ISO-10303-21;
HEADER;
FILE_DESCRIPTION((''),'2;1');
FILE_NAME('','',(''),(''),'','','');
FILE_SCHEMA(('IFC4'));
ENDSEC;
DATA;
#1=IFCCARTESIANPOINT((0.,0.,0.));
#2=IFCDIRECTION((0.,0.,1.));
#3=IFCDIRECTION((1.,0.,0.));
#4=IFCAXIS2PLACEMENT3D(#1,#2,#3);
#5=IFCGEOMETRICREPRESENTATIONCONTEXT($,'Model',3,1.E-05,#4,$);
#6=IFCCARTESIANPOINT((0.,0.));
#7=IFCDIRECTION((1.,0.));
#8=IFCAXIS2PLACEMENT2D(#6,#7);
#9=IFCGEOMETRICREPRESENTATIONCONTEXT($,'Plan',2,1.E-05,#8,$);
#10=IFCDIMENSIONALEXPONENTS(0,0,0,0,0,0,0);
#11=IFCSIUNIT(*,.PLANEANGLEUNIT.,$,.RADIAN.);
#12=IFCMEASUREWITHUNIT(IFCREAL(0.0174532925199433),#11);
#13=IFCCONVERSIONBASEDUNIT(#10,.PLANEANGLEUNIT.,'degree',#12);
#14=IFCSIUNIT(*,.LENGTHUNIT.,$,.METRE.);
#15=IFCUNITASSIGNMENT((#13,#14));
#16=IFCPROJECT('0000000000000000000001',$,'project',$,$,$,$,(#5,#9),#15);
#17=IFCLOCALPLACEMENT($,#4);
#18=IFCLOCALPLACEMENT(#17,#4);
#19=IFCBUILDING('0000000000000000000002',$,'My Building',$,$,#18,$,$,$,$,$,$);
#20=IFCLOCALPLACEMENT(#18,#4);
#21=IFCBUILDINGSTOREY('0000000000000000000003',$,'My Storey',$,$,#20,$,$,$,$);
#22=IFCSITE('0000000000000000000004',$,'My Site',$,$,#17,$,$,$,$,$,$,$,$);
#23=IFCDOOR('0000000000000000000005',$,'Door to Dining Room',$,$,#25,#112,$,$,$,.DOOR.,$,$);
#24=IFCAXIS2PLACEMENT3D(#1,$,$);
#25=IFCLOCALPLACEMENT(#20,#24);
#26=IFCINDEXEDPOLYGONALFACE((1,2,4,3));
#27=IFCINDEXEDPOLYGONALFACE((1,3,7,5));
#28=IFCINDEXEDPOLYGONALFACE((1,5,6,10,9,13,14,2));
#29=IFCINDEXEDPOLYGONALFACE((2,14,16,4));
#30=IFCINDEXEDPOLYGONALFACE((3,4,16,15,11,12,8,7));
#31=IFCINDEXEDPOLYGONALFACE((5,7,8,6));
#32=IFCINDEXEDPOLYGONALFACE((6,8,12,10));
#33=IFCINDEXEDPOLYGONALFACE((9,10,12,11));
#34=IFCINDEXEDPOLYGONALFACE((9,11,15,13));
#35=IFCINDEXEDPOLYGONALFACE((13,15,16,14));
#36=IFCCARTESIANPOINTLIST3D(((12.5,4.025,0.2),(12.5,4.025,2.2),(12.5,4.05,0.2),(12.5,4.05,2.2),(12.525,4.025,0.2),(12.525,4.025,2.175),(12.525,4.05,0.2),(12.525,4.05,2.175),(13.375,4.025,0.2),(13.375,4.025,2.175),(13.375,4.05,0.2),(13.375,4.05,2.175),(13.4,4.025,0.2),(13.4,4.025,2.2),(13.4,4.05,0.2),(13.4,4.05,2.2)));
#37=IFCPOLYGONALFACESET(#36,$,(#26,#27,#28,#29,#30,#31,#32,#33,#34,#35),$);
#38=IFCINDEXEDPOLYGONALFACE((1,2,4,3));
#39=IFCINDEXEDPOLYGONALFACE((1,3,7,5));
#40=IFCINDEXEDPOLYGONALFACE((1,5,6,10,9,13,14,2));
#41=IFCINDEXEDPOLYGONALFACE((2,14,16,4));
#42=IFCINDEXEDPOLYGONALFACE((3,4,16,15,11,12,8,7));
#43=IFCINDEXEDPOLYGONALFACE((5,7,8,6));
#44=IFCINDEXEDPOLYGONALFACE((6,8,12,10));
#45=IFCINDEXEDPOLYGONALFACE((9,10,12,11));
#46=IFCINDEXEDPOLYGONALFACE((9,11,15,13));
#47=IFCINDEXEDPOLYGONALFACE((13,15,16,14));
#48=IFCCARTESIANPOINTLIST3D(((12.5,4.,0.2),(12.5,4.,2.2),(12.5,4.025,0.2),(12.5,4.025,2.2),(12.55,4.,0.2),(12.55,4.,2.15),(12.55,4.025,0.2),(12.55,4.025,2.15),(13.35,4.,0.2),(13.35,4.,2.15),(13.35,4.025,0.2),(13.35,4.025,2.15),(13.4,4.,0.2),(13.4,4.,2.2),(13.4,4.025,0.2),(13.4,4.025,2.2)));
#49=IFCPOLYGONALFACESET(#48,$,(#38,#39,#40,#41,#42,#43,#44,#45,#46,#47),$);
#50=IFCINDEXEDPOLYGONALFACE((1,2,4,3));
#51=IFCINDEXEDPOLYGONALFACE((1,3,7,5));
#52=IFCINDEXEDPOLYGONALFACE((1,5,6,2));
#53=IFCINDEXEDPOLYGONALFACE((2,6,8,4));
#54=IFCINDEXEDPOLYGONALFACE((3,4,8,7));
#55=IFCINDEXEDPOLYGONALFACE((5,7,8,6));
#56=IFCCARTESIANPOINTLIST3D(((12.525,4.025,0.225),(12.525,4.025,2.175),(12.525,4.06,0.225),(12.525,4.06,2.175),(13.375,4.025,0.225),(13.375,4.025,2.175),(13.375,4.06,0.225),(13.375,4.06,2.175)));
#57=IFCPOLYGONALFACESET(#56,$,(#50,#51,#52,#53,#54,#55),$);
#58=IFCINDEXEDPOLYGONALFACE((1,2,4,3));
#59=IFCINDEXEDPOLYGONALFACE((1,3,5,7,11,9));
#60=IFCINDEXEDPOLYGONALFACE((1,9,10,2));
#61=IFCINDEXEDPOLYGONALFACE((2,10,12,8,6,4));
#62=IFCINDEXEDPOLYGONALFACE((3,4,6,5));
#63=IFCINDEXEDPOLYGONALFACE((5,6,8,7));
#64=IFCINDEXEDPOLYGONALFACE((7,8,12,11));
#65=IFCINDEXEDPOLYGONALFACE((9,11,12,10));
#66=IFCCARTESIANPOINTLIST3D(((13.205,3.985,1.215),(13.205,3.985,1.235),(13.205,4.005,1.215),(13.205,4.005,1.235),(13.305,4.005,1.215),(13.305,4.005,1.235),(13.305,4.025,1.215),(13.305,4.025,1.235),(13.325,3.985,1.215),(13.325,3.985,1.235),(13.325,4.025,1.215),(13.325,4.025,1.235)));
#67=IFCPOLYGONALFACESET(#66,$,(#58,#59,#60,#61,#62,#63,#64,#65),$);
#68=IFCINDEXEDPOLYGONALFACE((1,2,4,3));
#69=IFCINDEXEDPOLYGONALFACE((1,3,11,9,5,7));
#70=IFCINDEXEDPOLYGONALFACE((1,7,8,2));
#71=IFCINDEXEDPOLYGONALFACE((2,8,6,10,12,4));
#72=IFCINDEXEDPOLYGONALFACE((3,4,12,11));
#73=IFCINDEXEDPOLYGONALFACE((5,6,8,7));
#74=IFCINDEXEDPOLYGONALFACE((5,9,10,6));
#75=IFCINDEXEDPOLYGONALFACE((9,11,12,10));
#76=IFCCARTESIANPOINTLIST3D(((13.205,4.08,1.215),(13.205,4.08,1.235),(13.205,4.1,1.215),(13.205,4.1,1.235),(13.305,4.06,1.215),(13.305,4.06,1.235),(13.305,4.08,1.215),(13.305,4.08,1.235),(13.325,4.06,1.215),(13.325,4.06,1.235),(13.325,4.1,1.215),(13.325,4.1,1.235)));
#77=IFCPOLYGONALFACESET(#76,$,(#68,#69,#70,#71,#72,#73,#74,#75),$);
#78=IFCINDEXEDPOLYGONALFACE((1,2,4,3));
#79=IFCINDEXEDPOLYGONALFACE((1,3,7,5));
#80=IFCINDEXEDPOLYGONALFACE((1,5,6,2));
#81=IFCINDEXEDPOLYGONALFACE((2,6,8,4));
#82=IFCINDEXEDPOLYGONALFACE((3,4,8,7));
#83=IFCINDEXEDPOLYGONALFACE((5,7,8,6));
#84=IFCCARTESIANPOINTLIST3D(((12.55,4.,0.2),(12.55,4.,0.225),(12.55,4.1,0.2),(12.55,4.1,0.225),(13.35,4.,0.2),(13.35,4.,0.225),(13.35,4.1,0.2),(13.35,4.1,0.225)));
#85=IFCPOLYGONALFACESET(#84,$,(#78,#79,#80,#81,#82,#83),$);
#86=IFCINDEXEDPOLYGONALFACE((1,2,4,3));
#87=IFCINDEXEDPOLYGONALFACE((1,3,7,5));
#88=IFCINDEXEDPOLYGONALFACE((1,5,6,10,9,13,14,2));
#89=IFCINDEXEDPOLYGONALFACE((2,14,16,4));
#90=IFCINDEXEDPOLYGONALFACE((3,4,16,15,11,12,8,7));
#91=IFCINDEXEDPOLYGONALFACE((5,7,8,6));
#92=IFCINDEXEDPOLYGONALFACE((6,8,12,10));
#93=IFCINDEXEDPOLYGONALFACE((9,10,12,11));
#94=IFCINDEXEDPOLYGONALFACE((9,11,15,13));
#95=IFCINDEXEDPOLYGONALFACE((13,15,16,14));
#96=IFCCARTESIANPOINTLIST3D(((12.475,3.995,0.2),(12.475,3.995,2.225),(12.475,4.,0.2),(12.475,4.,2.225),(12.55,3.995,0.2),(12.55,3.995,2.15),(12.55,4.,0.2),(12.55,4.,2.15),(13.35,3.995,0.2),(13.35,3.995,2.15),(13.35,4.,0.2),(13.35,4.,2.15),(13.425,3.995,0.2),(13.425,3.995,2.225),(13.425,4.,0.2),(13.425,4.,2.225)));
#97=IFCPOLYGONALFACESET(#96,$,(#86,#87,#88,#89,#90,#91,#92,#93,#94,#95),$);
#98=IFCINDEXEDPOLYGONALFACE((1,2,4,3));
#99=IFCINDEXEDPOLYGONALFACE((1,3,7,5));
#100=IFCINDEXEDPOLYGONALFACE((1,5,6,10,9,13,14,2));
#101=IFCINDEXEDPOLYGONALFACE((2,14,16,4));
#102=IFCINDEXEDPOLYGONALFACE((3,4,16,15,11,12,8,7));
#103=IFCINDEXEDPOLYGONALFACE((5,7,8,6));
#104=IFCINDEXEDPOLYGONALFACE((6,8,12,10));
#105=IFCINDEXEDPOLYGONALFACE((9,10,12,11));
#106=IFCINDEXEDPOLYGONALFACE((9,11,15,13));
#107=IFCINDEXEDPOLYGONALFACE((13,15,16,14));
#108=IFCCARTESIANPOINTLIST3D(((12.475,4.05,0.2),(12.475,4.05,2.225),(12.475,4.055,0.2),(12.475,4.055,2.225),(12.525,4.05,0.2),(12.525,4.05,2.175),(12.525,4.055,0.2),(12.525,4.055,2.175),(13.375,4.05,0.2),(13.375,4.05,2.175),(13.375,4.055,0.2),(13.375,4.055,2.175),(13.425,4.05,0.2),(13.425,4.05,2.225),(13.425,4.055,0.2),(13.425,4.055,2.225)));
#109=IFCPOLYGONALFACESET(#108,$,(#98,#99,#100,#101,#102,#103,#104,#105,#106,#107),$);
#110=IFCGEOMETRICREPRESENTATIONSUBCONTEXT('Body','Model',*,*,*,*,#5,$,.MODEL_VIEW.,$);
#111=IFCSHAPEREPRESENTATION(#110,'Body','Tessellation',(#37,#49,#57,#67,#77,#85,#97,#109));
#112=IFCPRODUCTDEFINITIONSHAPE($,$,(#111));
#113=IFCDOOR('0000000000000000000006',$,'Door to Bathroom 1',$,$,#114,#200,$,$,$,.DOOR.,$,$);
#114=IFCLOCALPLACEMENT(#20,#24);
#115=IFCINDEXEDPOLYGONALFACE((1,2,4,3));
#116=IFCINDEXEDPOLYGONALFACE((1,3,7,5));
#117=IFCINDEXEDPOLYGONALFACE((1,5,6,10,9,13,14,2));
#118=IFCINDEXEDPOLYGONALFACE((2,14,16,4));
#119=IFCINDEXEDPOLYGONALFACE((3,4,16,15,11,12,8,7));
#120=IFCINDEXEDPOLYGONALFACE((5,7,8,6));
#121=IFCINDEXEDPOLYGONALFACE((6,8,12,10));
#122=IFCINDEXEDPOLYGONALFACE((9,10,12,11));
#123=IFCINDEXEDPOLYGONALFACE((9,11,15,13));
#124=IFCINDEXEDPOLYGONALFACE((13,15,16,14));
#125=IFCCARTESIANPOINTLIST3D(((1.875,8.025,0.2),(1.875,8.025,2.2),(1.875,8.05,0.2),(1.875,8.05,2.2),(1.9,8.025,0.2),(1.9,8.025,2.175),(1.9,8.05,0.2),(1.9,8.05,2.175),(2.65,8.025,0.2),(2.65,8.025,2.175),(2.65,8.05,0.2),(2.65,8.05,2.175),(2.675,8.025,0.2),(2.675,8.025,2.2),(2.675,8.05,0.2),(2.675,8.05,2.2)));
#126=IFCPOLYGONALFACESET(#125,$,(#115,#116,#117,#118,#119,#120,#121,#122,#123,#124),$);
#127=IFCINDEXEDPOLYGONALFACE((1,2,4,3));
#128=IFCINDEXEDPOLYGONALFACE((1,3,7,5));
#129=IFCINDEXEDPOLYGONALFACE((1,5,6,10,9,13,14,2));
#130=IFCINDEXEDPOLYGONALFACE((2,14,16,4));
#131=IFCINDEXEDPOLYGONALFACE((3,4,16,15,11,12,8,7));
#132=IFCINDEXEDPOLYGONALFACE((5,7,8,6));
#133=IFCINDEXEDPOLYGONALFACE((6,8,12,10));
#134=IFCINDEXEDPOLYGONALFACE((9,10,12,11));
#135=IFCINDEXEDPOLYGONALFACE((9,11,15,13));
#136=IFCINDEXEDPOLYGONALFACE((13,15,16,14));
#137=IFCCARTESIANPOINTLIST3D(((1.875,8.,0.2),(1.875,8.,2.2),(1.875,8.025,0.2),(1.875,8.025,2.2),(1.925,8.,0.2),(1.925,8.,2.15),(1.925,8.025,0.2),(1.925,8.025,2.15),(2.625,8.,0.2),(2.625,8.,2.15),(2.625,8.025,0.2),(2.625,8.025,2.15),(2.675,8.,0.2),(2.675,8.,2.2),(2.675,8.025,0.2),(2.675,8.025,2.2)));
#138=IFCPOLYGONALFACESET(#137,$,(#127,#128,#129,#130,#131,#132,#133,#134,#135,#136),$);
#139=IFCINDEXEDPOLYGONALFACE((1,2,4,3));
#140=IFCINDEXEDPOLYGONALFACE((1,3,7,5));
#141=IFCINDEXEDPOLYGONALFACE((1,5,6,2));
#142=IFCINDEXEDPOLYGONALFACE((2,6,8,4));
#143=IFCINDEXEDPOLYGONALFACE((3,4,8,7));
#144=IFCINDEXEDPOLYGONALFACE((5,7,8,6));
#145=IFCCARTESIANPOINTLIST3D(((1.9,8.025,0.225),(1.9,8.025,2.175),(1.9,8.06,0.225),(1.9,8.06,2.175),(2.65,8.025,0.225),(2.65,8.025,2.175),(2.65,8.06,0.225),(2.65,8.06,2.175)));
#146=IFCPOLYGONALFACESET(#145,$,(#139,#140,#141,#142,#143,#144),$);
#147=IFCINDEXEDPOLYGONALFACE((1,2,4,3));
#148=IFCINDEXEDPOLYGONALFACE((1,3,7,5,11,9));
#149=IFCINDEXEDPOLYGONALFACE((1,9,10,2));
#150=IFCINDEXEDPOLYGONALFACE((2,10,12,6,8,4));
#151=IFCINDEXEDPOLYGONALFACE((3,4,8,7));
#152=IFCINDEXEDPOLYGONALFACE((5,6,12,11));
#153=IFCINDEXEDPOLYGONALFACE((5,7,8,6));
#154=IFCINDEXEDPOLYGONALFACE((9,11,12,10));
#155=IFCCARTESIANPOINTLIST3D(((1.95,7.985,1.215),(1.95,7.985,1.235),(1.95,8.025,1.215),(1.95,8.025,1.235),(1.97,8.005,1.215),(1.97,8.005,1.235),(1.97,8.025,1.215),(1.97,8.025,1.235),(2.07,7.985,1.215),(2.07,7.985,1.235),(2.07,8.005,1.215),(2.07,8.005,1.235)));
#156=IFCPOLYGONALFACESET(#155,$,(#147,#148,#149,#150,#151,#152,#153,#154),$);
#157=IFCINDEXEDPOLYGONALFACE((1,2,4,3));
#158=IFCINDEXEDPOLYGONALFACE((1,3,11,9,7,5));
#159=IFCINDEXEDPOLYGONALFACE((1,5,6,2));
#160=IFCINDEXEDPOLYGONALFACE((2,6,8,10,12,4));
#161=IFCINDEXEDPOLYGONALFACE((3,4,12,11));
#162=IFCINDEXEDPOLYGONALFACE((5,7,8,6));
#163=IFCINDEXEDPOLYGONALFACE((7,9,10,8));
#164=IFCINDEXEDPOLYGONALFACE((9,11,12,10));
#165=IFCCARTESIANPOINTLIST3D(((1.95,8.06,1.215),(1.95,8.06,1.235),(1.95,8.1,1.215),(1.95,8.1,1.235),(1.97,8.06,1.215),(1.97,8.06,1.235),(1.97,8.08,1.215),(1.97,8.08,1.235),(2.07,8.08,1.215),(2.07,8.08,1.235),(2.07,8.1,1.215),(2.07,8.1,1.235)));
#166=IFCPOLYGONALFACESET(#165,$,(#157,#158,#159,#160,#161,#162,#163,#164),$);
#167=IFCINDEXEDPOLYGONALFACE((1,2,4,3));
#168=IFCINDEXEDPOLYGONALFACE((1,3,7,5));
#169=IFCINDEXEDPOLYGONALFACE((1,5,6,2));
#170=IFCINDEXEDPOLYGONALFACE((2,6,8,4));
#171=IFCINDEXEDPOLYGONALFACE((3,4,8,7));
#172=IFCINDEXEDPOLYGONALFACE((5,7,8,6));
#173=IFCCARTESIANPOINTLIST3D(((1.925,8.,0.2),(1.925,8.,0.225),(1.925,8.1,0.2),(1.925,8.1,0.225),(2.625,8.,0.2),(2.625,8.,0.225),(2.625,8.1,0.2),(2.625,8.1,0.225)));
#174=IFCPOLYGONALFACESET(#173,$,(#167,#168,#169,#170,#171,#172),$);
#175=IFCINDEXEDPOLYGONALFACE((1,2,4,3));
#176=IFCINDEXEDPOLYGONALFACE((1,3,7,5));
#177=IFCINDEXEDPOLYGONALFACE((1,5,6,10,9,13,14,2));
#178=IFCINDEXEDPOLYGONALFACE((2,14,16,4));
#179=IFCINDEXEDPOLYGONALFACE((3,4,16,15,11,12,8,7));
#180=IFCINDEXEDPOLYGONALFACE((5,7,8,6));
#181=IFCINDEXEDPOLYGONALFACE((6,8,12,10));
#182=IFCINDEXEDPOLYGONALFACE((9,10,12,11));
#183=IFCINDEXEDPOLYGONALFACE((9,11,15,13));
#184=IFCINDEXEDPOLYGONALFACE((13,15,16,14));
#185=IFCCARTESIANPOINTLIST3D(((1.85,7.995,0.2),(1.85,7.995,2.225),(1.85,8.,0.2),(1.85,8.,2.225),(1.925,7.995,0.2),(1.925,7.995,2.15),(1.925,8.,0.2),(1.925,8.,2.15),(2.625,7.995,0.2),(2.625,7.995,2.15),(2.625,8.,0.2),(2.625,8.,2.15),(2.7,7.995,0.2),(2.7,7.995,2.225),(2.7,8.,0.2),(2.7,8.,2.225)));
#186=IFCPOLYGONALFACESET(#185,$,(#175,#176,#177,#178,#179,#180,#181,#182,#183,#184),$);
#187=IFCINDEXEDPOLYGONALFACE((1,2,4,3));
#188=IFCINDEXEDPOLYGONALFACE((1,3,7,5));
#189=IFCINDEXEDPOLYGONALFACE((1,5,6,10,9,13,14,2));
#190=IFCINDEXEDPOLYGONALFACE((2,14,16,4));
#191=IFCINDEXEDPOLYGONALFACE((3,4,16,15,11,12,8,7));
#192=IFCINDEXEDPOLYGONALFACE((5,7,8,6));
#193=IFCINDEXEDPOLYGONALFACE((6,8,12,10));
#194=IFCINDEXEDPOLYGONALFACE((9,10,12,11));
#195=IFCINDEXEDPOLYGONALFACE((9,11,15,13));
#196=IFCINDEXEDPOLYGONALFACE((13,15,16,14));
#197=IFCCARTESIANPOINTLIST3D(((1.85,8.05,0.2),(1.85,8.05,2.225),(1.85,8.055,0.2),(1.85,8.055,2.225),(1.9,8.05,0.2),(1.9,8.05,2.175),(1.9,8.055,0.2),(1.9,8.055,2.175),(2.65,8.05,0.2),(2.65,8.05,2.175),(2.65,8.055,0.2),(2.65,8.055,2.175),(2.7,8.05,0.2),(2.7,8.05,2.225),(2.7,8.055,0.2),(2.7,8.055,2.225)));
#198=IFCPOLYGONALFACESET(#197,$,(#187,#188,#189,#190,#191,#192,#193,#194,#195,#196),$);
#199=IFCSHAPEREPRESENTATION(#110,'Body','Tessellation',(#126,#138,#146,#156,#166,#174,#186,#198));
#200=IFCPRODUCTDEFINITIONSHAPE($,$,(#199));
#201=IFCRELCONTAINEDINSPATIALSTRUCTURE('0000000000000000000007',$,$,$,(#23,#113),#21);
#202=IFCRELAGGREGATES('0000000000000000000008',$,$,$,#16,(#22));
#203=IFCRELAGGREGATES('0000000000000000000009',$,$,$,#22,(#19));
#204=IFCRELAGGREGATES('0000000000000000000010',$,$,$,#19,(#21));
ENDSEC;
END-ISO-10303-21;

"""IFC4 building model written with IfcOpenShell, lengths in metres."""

from ifc_helpers import new_model, entity, si_unit, converted_unit, frame, origin_with_axes, origin_2d_with_axis, place, context, subcontext, project, spatial, line, indexed_curve, outline, extrude, element, save


model = new_model("IFC4")

# Units and contexts
model_context = context("Model", 3, precision=1e-05, world=origin_with_axes())
plan_context = context("Plan", 2, precision=1e-05, world=origin_2d_with_axis())
body_context = subcontext(model_context, "Body", "Model", "MODEL_VIEW")
ifc_project = project(units=[converted_unit("PLANEANGLEUNIT", "degree", entity("IfcReal", 0.0174532925199433), si_unit("PLANEANGLEUNIT", "RADIAN"), dimensions=[0, 0, 0, 0, 0, 0, 0]), si_unit("LENGTHUNIT", "METRE")], contexts=[model_context, plan_context])

# Site, building, storey
site_placement = place(None, origin_with_axes())
site = spatial("IfcSite", under=ifc_project, at=site_placement, Name="My Site")
building_placement = place(site_placement, origin_with_axes())
building = spatial("IfcBuilding", under=site, at=building_placement, Name="My Building")
storey_placement = place(building_placement, origin_with_axes())
storey = spatial("IfcBuildingStorey", under=building, at=storey_placement, Name="My Storey")

# Doors
door_1_placement = place(storey_placement, frame((12.5, 4.0, 0.2), z_axis=(0.0, 0.0, 1.0), x_axis=(1.0, 0.0, 0.0)))
element("IfcDoor", 1, at=door_1_placement, inside=storey, Name="Door to Dining Room", PredefinedType="DOOR", context=body_context, shape_type="SweptSolid", body=[
    extrude(outline(indexed_curve([(0.0, 0.0), (0.0, 2.0), (0.9, 2.0), (0.9, 0.0), (0.875, 0.0), (0.875, 1.975), (0.025, 1.975), (0.025, 0.0)], segments=[line(1, 2, 3, 4, 5, 6, 7, 8, 1)])), frame((0.0, 0.025, 0.0), z_axis=(0.0, -1.0, 0.0), x_axis=(1.0, 0.0, 0.0)), (0.0, 0.0, -1.0), 0.025),
    extrude(outline(indexed_curve([(0.0, 0.0), (0.0, 2.0), (0.9, 2.0), (0.9, 0.0), (0.85, 0.0), (0.85, 1.95), (0.05, 1.95), (0.05, 0.0)], segments=[line(1, 2, 3, 4, 5, 6, 7, 8, 1)])), frame((0.0, 0.0, 0.0), z_axis=(0.0, -1.0, 0.0), x_axis=(1.0, 0.0, 0.0)), (0.0, 0.0, -1.0), 0.025),
    extrude(outline(indexed_curve([(0.0, 0.0), (0.85, 0.0), (0.85, 0.035), (0.0, 0.035)], segments=[line(1, 2, 3, 4, 1)])), frame((0.025, 0.025, 0.025), z_axis=(0.0, 0.0, 1.0), x_axis=(1.0, 0.0, 0.0)), (0.0, 0.0, 1.0), 1.95),
    extrude(outline(indexed_curve([(0.0, 0.0), (0.0, -0.04), (-0.12, -0.04), (-0.12, -0.02), (-0.02, -0.02), (-0.02, 0.0)], segments=[line(1, 2, 3, 4, 5, 6, 1)])), frame((0.825, 0.025, 1.015), z_axis=(0.0, 0.0, 1.0), x_axis=(1.0, 0.0, 0.0)), (0.0, 0.0, 1.0), 0.02),
    extrude(outline(indexed_curve([(0.0, 0.0), (0.0, 0.04), (-0.12, 0.04), (-0.12, 0.02), (-0.02, 0.02), (-0.02, 0.0)], segments=[line(1, 2, 3, 4, 5, 6, 1)])), frame((0.825, 0.06, 1.015), z_axis=(0.0, 0.0, 1.0), x_axis=(1.0, 0.0, 0.0)), (0.0, 0.0, 1.0), 0.02),
    extrude(outline(indexed_curve([(0.0, 0.0), (0.8, 0.0), (0.8, 0.1), (0.0, 0.1)], segments=[line(1, 2, 3, 4, 1)])), frame((0.05, 0.0, 0.0), z_axis=(0.0, 0.0, 1.0), x_axis=(1.0, 0.0, 0.0)), (0.0, 0.0, 1.0), 0.025),
    extrude(outline(indexed_curve([(0.0, 0.0), (0.0, 2.025), (0.95, 2.025), (0.95, 0.0), (0.875, 0.0), (0.875, 1.95), (0.075, 1.95), (0.075, 0.0)], segments=[line(1, 2, 3, 4, 5, 6, 7, 8, 1)])), frame((-0.025, -0.005, 0.0), z_axis=(0.0, -1.0, 0.0), x_axis=(1.0, 0.0, 0.0)), (0.0, 0.0, -1.0), 0.005),
    extrude(outline(indexed_curve([(0.0, 0.0), (0.0, 2.025), (0.95, 2.025), (0.95, 0.0), (0.9, 0.0), (0.9, 1.975), (0.05, 1.975), (0.05, 0.0)], segments=[line(1, 2, 3, 4, 5, 6, 7, 8, 1)])), frame((-0.025, 0.05, 0.0), z_axis=(0.0, -1.0, 0.0), x_axis=(1.0, 0.0, 0.0)), (0.0, 0.0, -1.0), 0.005),
])
door_2_placement = place(storey_placement, frame((1.875, 8.0, 0.2), z_axis=(0.0, 0.0, 1.0), x_axis=(1.0, 0.0, 0.0)))
element("IfcDoor", 2, at=door_2_placement, inside=storey, Name="Door to Bathroom 1", PredefinedType="DOOR", context=body_context, shape_type="SweptSolid", body=[
    extrude(outline(indexed_curve([(0.0, 0.0), (0.0, 2.0), (0.8, 2.0), (0.8, 0.0), (0.775, 0.0), (0.775, 1.975), (0.025, 1.975), (0.025, 0.0)], segments=[line(1, 2, 3, 4, 5, 6, 7, 8, 1)])), frame((0.0, 0.025, 0.0), z_axis=(0.0, -1.0, 0.0), x_axis=(1.0, 0.0, 0.0)), (0.0, 0.0, -1.0), 0.025),
    extrude(outline(indexed_curve([(0.0, 0.0), (0.0, 2.0), (0.8, 2.0), (0.8, 0.0), (0.75, 0.0), (0.75, 1.95), (0.05, 1.95), (0.05, 0.0)], segments=[line(1, 2, 3, 4, 5, 6, 7, 8, 1)])), frame((0.0, 0.0, 0.0), z_axis=(0.0, -1.0, 0.0), x_axis=(1.0, 0.0, 0.0)), (0.0, 0.0, -1.0), 0.025),
    extrude(outline(indexed_curve([(0.0, 0.0), (0.75, 0.0), (0.75, 0.035), (0.0, 0.035)], segments=[line(1, 2, 3, 4, 1)])), frame((0.025, 0.025, 0.025), z_axis=(0.0, 0.0, 1.0), x_axis=(1.0, 0.0, 0.0)), (0.0, 0.0, 1.0), 1.95),
    extrude(outline(indexed_curve([(0.0, 0.0), (0.0, -0.04), (0.12, -0.04), (0.12, -0.02), (0.02, -0.02), (0.02, 0.0)], segments=[line(1, 2, 3, 4, 5, 6, 1)])), frame((0.075, 0.025, 1.015), z_axis=(0.0, 0.0, 1.0), x_axis=(1.0, 0.0, 0.0)), (0.0, 0.0, 1.0), 0.02),
    extrude(outline(indexed_curve([(0.0, 0.0), (0.0, 0.04), (0.12, 0.04), (0.12, 0.02), (0.02, 0.02), (0.02, 0.0)], segments=[line(1, 2, 3, 4, 5, 6, 1)])), frame((0.075, 0.06, 1.015), z_axis=(0.0, 0.0, 1.0), x_axis=(1.0, 0.0, 0.0)), (0.0, 0.0, 1.0), 0.02),
    extrude(outline(indexed_curve([(0.0, 0.0), (0.7, 0.0), (0.7, 0.1), (0.0, 0.1)], segments=[line(1, 2, 3, 4, 1)])), frame((0.05, 0.0, 0.0), z_axis=(0.0, 0.0, 1.0), x_axis=(1.0, 0.0, 0.0)), (0.0, 0.0, 1.0), 0.025),
    extrude(outline(indexed_curve([(0.0, 0.0), (0.0, 2.025), (0.85, 2.025), (0.85, 0.0), (0.775, 0.0), (0.775, 1.95), (0.075, 1.95), (0.075, 0.0)], segments=[line(1, 2, 3, 4, 5, 6, 7, 8, 1)])), frame((-0.025, -0.005, 0.0), z_axis=(0.0, -1.0, 0.0), x_axis=(1.0, 0.0, 0.0)), (0.0, 0.0, -1.0), 0.005),
    extrude(outline(indexed_curve([(0.0, 0.0), (0.0, 2.025), (0.85, 2.025), (0.85, 0.0), (0.8, 0.0), (0.8, 1.975), (0.05, 1.975), (0.05, 0.0)], segments=[line(1, 2, 3, 4, 5, 6, 7, 8, 1)])), frame((-0.025, 0.05, 0.0), z_axis=(0.0, -1.0, 0.0), x_axis=(1.0, 0.0, 0.0)), (0.0, 0.0, -1.0), 0.005),
])

save(model, "model.ifc")
